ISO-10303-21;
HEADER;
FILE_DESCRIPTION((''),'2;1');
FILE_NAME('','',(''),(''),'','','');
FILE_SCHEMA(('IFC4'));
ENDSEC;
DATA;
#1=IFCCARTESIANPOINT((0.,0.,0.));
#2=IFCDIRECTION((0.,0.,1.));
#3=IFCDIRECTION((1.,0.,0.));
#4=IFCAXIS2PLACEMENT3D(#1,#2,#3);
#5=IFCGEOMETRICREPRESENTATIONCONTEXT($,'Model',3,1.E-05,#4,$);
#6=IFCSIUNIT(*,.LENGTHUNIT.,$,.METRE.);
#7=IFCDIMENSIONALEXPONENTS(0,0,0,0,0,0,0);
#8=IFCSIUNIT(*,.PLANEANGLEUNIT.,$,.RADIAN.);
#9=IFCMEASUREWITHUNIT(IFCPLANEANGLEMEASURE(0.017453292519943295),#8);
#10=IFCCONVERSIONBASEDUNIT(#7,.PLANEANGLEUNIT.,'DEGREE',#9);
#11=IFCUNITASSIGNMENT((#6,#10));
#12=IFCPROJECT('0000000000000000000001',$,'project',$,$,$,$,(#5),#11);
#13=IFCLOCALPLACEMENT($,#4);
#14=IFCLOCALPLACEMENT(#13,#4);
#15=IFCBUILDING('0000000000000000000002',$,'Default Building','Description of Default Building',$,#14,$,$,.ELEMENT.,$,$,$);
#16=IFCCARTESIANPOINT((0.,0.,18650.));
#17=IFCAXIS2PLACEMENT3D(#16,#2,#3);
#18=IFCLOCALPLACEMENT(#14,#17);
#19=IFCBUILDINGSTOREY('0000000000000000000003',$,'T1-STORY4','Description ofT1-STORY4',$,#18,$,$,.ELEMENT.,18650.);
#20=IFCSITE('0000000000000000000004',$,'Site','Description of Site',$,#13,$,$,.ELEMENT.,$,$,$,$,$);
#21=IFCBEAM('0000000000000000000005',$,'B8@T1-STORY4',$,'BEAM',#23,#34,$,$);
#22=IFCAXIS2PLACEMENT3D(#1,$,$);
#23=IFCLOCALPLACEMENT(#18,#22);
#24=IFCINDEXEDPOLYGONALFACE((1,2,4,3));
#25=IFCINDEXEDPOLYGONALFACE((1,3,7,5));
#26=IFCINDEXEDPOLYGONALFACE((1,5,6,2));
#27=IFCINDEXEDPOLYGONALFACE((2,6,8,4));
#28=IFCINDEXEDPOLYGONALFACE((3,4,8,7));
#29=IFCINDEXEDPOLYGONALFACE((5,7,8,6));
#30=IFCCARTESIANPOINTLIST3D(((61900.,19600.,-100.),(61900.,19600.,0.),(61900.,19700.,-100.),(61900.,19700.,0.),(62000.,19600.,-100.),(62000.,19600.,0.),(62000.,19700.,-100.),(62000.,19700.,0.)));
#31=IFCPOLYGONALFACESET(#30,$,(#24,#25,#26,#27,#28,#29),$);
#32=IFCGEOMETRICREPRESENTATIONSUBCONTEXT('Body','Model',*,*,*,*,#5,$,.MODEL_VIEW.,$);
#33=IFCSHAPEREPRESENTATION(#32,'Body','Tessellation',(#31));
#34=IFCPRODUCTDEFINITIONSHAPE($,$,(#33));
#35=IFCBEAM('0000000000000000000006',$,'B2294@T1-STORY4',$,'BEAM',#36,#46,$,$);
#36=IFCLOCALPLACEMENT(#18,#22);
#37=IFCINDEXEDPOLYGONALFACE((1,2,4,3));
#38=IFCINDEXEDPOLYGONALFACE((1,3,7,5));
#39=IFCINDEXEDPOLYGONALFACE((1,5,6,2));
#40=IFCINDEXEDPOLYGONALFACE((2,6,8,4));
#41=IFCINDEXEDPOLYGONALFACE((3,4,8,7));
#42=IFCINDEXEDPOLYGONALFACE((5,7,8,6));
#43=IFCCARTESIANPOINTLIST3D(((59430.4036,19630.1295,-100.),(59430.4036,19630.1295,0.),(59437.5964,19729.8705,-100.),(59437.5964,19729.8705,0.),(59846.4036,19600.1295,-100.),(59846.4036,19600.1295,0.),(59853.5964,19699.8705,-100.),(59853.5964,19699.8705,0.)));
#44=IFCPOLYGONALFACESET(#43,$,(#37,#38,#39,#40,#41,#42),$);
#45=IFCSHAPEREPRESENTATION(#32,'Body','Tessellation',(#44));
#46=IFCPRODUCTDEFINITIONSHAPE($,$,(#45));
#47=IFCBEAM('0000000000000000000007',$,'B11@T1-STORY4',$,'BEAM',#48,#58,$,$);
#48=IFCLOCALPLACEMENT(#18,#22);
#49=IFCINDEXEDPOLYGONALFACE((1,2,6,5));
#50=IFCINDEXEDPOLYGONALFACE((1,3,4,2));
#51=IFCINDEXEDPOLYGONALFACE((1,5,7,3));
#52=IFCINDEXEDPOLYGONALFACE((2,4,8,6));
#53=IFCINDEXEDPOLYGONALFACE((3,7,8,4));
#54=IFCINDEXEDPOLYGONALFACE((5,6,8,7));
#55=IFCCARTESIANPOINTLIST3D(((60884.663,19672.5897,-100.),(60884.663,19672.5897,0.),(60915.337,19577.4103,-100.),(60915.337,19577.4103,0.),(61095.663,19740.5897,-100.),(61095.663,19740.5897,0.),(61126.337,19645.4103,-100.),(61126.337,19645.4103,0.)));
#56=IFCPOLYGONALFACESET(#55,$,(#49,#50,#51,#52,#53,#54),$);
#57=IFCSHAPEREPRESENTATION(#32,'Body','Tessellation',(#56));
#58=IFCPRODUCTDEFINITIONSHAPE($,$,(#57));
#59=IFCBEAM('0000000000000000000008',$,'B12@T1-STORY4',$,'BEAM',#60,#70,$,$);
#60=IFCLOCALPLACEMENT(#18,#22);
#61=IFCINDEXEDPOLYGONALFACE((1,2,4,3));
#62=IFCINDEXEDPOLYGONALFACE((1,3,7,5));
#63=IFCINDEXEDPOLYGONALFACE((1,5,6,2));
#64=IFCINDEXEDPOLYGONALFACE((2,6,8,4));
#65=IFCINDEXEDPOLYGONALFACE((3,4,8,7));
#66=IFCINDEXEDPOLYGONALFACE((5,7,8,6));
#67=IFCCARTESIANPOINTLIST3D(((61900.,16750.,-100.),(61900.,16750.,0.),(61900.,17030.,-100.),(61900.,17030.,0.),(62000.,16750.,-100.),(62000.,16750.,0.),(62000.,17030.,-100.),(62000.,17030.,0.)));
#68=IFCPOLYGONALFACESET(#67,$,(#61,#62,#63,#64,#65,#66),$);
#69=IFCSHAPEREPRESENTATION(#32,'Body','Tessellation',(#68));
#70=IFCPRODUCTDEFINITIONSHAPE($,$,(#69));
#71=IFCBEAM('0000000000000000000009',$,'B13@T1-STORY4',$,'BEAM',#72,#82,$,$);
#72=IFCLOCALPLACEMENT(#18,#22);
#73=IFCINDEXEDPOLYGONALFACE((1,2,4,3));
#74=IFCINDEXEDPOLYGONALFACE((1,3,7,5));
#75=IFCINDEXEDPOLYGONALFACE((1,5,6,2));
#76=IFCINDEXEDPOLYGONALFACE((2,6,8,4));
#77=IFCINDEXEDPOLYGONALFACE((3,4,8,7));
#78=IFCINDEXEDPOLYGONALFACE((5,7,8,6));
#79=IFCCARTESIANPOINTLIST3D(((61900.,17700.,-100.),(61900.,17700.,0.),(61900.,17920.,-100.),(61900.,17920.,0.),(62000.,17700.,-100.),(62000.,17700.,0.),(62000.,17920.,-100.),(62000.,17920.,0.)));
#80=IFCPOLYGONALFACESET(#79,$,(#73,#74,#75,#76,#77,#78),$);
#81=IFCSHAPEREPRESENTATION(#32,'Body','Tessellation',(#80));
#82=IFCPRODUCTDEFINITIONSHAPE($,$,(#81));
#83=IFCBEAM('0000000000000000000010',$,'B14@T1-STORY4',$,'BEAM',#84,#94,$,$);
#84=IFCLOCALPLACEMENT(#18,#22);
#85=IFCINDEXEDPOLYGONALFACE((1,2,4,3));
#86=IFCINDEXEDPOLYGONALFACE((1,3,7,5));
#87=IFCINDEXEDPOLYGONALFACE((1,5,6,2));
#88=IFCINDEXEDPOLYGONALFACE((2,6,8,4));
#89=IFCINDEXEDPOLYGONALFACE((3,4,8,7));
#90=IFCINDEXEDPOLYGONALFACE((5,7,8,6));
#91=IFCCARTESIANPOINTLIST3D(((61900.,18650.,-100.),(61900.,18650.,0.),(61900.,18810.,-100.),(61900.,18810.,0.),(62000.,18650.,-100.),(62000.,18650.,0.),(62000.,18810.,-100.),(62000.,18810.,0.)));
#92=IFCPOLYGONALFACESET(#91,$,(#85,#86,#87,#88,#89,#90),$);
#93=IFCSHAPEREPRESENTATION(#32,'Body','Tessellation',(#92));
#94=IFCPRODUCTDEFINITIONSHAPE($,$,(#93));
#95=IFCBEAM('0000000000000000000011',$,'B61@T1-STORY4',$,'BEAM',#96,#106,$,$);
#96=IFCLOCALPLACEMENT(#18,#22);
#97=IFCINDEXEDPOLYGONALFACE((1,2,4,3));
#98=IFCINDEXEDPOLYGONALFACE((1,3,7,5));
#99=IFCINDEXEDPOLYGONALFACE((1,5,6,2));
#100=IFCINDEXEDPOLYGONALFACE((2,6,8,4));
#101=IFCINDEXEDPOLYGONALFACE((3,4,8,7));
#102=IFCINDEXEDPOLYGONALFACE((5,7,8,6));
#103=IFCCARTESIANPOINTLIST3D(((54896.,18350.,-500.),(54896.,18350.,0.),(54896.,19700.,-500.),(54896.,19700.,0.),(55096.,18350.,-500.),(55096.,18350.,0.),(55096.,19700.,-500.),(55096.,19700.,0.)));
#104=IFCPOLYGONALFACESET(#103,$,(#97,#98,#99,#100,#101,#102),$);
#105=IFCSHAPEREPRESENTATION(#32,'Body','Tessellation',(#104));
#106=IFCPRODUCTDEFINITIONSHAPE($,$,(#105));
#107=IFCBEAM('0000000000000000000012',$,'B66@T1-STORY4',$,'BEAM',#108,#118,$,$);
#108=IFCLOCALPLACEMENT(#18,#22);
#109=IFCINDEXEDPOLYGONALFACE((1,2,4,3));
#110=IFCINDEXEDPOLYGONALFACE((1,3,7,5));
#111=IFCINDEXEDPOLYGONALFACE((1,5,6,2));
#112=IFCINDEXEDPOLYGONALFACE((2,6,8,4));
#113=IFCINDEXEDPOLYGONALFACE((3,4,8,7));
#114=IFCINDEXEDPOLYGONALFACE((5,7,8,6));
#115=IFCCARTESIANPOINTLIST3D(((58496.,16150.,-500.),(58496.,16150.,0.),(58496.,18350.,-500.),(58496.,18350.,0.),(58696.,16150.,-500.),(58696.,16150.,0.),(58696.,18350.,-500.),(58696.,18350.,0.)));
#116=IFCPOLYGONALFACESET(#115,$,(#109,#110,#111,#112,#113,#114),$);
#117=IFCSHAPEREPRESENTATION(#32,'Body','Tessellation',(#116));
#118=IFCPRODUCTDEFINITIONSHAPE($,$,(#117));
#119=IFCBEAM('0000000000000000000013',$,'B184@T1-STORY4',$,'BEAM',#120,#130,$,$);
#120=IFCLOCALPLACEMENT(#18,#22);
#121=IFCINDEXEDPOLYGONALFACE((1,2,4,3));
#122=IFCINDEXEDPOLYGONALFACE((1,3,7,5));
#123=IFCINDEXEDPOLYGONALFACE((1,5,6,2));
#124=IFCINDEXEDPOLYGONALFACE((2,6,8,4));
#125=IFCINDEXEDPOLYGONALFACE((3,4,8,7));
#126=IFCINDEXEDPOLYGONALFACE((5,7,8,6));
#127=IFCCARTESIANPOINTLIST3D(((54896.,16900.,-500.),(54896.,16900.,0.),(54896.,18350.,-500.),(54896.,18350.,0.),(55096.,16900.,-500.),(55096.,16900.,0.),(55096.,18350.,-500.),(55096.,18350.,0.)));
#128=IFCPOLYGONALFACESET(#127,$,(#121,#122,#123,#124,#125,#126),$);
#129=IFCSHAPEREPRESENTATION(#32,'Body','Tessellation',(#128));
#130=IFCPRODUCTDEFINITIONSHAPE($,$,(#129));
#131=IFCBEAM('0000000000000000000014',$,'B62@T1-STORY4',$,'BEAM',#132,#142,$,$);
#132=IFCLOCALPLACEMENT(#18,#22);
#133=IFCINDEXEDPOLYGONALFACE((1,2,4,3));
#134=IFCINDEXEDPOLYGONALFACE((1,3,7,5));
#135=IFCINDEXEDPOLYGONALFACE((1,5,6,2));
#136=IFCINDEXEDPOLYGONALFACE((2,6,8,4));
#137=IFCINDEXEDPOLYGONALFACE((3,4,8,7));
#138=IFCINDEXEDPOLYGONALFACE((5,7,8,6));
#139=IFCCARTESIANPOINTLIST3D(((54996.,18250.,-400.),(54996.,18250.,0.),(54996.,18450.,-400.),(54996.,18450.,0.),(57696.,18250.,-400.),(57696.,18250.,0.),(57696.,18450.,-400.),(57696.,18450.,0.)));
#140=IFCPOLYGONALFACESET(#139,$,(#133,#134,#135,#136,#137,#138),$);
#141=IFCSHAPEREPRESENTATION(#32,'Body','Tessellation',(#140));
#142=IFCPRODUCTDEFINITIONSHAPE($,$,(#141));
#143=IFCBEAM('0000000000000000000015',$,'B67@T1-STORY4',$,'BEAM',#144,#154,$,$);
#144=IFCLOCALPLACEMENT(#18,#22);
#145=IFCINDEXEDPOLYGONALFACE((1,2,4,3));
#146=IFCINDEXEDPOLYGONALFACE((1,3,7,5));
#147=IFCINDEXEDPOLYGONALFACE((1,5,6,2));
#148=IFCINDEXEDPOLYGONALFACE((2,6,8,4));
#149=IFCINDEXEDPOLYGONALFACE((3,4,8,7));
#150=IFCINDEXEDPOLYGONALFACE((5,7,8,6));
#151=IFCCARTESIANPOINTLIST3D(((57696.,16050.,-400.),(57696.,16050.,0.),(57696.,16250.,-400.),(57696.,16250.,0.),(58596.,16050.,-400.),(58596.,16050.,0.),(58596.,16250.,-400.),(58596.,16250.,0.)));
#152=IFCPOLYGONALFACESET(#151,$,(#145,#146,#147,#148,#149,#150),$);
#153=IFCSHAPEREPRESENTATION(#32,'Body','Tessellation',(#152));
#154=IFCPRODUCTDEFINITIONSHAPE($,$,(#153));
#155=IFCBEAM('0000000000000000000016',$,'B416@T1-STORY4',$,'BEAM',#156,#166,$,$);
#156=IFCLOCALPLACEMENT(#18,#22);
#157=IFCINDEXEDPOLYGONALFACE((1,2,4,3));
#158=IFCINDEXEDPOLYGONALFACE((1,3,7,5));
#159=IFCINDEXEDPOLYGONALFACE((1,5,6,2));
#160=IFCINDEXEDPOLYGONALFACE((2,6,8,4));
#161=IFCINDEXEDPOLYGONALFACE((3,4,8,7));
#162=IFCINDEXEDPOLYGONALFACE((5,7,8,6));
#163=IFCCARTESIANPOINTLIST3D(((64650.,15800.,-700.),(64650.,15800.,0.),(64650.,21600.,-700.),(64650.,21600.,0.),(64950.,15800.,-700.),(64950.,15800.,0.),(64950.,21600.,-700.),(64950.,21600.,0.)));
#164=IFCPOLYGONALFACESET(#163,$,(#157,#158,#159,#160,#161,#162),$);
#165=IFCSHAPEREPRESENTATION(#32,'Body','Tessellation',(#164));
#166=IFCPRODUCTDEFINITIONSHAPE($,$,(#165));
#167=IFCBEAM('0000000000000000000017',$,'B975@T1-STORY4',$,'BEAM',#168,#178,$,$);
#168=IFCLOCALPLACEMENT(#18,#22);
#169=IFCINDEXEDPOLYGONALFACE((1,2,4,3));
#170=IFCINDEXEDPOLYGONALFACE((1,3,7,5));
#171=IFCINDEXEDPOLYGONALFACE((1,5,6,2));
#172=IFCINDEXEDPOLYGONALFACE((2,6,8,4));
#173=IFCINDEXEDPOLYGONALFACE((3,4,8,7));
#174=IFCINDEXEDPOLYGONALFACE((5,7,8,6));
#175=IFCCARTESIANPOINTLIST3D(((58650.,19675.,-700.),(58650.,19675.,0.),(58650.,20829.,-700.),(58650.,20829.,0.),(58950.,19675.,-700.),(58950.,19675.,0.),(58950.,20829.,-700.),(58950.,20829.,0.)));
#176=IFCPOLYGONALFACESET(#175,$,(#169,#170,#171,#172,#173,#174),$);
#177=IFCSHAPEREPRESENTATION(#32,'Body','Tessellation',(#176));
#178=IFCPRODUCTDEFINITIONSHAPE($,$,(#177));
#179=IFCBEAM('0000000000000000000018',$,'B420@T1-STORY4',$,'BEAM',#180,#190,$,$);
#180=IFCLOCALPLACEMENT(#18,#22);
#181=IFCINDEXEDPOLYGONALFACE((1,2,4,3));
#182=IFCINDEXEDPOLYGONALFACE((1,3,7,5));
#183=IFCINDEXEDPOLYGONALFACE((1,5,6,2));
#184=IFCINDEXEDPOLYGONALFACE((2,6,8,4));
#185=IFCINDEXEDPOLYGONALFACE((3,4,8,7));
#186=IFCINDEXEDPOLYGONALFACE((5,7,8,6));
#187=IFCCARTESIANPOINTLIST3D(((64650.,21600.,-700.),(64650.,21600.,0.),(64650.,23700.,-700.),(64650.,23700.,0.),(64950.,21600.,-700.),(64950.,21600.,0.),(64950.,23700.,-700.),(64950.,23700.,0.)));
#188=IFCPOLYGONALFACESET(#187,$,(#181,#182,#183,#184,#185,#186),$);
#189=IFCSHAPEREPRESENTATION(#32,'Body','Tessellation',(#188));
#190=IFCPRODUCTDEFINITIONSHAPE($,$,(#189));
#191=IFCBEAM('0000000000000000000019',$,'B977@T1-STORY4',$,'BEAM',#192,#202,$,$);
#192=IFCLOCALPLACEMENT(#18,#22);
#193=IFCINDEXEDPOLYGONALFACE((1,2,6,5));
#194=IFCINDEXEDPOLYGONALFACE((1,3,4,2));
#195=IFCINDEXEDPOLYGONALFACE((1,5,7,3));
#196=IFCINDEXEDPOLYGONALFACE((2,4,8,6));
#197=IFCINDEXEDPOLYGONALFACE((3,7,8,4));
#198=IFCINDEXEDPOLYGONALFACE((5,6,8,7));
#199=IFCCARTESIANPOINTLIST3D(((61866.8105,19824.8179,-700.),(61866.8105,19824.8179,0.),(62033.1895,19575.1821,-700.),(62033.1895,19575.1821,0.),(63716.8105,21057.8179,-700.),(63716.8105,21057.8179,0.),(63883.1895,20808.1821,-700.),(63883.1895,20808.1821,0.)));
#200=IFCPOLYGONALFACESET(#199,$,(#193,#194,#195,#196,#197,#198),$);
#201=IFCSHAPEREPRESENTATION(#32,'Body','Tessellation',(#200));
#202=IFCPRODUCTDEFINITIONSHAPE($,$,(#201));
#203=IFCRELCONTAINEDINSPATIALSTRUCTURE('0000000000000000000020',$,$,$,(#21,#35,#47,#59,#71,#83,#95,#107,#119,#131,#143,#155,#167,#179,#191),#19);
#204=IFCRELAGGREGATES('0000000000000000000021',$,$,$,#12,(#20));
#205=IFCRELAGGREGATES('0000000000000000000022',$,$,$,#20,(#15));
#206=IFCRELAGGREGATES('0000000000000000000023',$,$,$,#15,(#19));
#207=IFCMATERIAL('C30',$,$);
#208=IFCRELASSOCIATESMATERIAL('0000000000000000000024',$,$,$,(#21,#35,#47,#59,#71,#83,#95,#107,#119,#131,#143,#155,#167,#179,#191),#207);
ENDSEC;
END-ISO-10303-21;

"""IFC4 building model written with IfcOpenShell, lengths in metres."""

from ifc_helpers import new_model, entity, si_unit, converted_unit, frame, origin_with_axes, place, context, subcontext, project, spatial, rectangle, extrude, material, element, save


model = new_model("IFC4")

# Units and contexts
model_context = context("Model", 3, precision=1e-05, world=origin_with_axes())
body_context = subcontext(model_context, "Body", "Model", "MODEL_VIEW")
ifc_project = project(units=[si_unit("LENGTHUNIT", "METRE"), converted_unit("PLANEANGLEUNIT", "DEGREE", entity("IfcPlaneAngleMeasure", 0.017453292519943295), si_unit("PLANEANGLEUNIT", "RADIAN"), dimensions=[0, 0, 0, 0, 0, 0, 0])], contexts=[model_context])

# Site, building, storey
site_placement = place(None, origin_with_axes())
site = spatial("IfcSite", under=ifc_project, at=site_placement, Name="Site", Description="Description of Site", CompositionType="ELEMENT")
building_placement = place(site_placement, origin_with_axes())
building = spatial("IfcBuilding", under=site, at=building_placement, Name="Default Building", Description="Description of Default Building", CompositionType="ELEMENT")
storey_placement = place(building_placement, frame((0.0, 0.0, 18650.0), z_axis=(0.0, 0.0, 1.0), x_axis=(1.0, 0.0, 0.0)))
storey = spatial("IfcBuildingStorey", under=building, at=storey_placement, Name="T1-STORY4", Description="Description ofT1-STORY4", CompositionType="ELEMENT", Elevation=18650.0)

# Beams
ifc_material_1 = material(Name="C30")
beam_1_placement = place(storey_placement, frame((61950.0, 19600.0, -50.0), z_axis=(0.0, 1.0, 0.0), x_axis=(-1.0, 0.0, 0.0)))
element("IfcBeam", 1, at=beam_1_placement, inside=storey, material=ifc_material_1, Name="B8@T1-STORY4", ObjectType="BEAM", context=body_context, shape_type="SweptSolid", body=[
    extrude(rectangle(XDim=100.0, YDim=100.0), origin_with_axes(), (0.0, 0.0, 1.0), 100.0),
])
beam_2_placement = place(storey_placement, frame((59434.0, 19680.0, -50.0), z_axis=(0.99741, -0.071929, 0.0), x_axis=(0.071929, 0.99741, 0.0)))
element("IfcBeam", 2, at=beam_2_placement, inside=storey, material=ifc_material_1, Name="B2294@T1-STORY4", ObjectType="BEAM", context=body_context, shape_type="SweptSolid", body=[
    extrude(rectangle(XDim=100.0, YDim=100.0), origin_with_axes(), (0.0, 0.0, 1.0), 417.0803),
])
beam_3_placement = place(storey_placement, frame((60900.0, 19625.0, -50.0), z_axis=(0.951794, 0.306739, 0.0), x_axis=(-0.306739, 0.951794, 0.0)))
element("IfcBeam", 3, at=beam_3_placement, inside=storey, material=ifc_material_1, Name="B11@T1-STORY4", ObjectType="BEAM", context=body_context, shape_type="SweptSolid", body=[
    extrude(rectangle(XDim=100.0, YDim=100.0), origin_with_axes(), (0.0, 0.0, 1.0), 221.6867),
])
beam_4_placement = place(storey_placement, frame((61950.0, 16750.0, -50.0), z_axis=(0.0, 1.0, 0.0), x_axis=(-1.0, 0.0, 0.0)))
element("IfcBeam", 4, at=beam_4_placement, inside=storey, material=ifc_material_1, Name="B12@T1-STORY4", ObjectType="BEAM", context=body_context, shape_type="SweptSolid", body=[
    extrude(rectangle(XDim=100.0, YDim=100.0), origin_with_axes(), (0.0, 0.0, 1.0), 280.0),
])
beam_5_placement = place(storey_placement, frame((61950.0, 17700.0, -50.0), z_axis=(0.0, 1.0, 0.0), x_axis=(-1.0, 0.0, 0.0)))
element("IfcBeam", 5, at=beam_5_placement, inside=storey, material=ifc_material_1, Name="B13@T1-STORY4", ObjectType="BEAM", context=body_context, shape_type="SweptSolid", body=[
    extrude(rectangle(XDim=100.0, YDim=100.0), origin_with_axes(), (0.0, 0.0, 1.0), 220.0),
])
beam_6_placement = place(storey_placement, frame((61950.0, 18650.0, -50.0), z_axis=(0.0, 1.0, 0.0), x_axis=(-1.0, 0.0, 0.0)))
element("IfcBeam", 6, at=beam_6_placement, inside=storey, material=ifc_material_1, Name="B14@T1-STORY4", ObjectType="BEAM", context=body_context, shape_type="SweptSolid", body=[
    extrude(rectangle(XDim=100.0, YDim=100.0), origin_with_axes(), (0.0, 0.0, 1.0), 160.0),
])
beam_7_placement = place(storey_placement, frame((54996.0, 18350.0, -250.0), z_axis=(0.0, 1.0, 0.0), x_axis=(-1.0, 0.0, 0.0)))
element("IfcBeam", 7, at=beam_7_placement, inside=storey, material=ifc_material_1, Name="B61@T1-STORY4", ObjectType="BEAM", context=body_context, shape_type="SweptSolid", body=[
    extrude(rectangle(XDim=200.0, YDim=500.0), origin_with_axes(), (0.0, 0.0, 1.0), 1350.0),
])
beam_8_placement = place(storey_placement, frame((58596.0, 16150.0, -250.0), z_axis=(0.0, 1.0, 0.0), x_axis=(-1.0, 0.0, 0.0)))
element("IfcBeam", 8, at=beam_8_placement, inside=storey, material=ifc_material_1, Name="B66@T1-STORY4", ObjectType="BEAM", context=body_context, shape_type="SweptSolid", body=[
    extrude(rectangle(XDim=200.0, YDim=500.0), origin_with_axes(), (0.0, 0.0, 1.0), 2200.0),
])
beam_9_placement = place(storey_placement, frame((54996.0, 16900.0, -250.0), z_axis=(0.0, 1.0, 0.0), x_axis=(-1.0, 0.0, 0.0)))
element("IfcBeam", 9, at=beam_9_placement, inside=storey, material=ifc_material_1, Name="B184@T1-STORY4", ObjectType="BEAM", context=body_context, shape_type="SweptSolid", body=[
    extrude(rectangle(XDim=200.0, YDim=500.0), origin_with_axes(), (0.0, 0.0, 1.0), 1450.0),
])
beam_10_placement = place(storey_placement, frame((54996.0, 18350.0, -200.0), z_axis=(1.0, 0.0, 0.0), x_axis=(0.0, 1.0, 0.0)))
element("IfcBeam", 10, at=beam_10_placement, inside=storey, material=ifc_material_1, Name="B62@T1-STORY4", ObjectType="BEAM", context=body_context, shape_type="SweptSolid", body=[
    extrude(rectangle(XDim=200.0, YDim=400.0), origin_with_axes(), (0.0, 0.0, 1.0), 2700.0),
])
beam_11_placement = place(storey_placement, frame((57696.0, 16150.0, -200.0), z_axis=(1.0, 0.0, 0.0), x_axis=(0.0, 1.0, 0.0)))
element("IfcBeam", 11, at=beam_11_placement, inside=storey, material=ifc_material_1, Name="B67@T1-STORY4", ObjectType="BEAM", context=body_context, shape_type="SweptSolid", body=[
    extrude(rectangle(XDim=200.0, YDim=400.0), origin_with_axes(), (0.0, 0.0, 1.0), 900.0),
])
beam_12_placement = place(storey_placement, frame((64800.0, 15800.0, -350.0), z_axis=(0.0, 1.0, 0.0), x_axis=(-1.0, 0.0, 0.0)))
element("IfcBeam", 12, at=beam_12_placement, inside=storey, material=ifc_material_1, Name="B416@T1-STORY4", ObjectType="BEAM", context=body_context, shape_type="SweptSolid", body=[
    extrude(rectangle(XDim=300.0, YDim=700.0), origin_with_axes(), (0.0, 0.0, 1.0), 5800.0),
])
beam_13_placement = place(storey_placement, frame((58800.0, 19675.0, -350.0), z_axis=(0.0, 1.0, 0.0), x_axis=(-1.0, 0.0, 0.0)))
element("IfcBeam", 13, at=beam_13_placement, inside=storey, material=ifc_material_1, Name="B975@T1-STORY4", ObjectType="BEAM", context=body_context, shape_type="SweptSolid", body=[
    extrude(rectangle(XDim=300.0, YDim=700.0), origin_with_axes(), (0.0, 0.0, 1.0), 1154.0),
])
beam_14_placement = place(storey_placement, frame((64800.0, 21600.0, -350.0), z_axis=(0.0, 1.0, 0.0), x_axis=(-1.0, 0.0, 0.0)))
element("IfcBeam", 14, at=beam_14_placement, inside=storey, material=ifc_material_1, Name="B420@T1-STORY4", ObjectType="BEAM", context=body_context, shape_type="SweptSolid", body=[
    extrude(rectangle(XDim=300.0, YDim=700.0), origin_with_axes(), (0.0, 0.0, 1.0), 2100.0),
])
beam_15_placement = place(storey_placement, frame((61950.0, 19700.0, -350.0), z_axis=(0.832119, 0.554596, 0.0), x_axis=(-0.554596, 0.832119, 0.0)))
element("IfcBeam", 15, at=beam_15_placement, inside=storey, material=ifc_material_1, Name="B977@T1-STORY4", ObjectType="BEAM", context=body_context, shape_type="SweptSolid", body=[
    extrude(rectangle(XDim=300.0, YDim=700.0), origin_with_axes(), (0.0, 0.0, 1.0), 2223.2384),
])

save(model, "model.ifc")
